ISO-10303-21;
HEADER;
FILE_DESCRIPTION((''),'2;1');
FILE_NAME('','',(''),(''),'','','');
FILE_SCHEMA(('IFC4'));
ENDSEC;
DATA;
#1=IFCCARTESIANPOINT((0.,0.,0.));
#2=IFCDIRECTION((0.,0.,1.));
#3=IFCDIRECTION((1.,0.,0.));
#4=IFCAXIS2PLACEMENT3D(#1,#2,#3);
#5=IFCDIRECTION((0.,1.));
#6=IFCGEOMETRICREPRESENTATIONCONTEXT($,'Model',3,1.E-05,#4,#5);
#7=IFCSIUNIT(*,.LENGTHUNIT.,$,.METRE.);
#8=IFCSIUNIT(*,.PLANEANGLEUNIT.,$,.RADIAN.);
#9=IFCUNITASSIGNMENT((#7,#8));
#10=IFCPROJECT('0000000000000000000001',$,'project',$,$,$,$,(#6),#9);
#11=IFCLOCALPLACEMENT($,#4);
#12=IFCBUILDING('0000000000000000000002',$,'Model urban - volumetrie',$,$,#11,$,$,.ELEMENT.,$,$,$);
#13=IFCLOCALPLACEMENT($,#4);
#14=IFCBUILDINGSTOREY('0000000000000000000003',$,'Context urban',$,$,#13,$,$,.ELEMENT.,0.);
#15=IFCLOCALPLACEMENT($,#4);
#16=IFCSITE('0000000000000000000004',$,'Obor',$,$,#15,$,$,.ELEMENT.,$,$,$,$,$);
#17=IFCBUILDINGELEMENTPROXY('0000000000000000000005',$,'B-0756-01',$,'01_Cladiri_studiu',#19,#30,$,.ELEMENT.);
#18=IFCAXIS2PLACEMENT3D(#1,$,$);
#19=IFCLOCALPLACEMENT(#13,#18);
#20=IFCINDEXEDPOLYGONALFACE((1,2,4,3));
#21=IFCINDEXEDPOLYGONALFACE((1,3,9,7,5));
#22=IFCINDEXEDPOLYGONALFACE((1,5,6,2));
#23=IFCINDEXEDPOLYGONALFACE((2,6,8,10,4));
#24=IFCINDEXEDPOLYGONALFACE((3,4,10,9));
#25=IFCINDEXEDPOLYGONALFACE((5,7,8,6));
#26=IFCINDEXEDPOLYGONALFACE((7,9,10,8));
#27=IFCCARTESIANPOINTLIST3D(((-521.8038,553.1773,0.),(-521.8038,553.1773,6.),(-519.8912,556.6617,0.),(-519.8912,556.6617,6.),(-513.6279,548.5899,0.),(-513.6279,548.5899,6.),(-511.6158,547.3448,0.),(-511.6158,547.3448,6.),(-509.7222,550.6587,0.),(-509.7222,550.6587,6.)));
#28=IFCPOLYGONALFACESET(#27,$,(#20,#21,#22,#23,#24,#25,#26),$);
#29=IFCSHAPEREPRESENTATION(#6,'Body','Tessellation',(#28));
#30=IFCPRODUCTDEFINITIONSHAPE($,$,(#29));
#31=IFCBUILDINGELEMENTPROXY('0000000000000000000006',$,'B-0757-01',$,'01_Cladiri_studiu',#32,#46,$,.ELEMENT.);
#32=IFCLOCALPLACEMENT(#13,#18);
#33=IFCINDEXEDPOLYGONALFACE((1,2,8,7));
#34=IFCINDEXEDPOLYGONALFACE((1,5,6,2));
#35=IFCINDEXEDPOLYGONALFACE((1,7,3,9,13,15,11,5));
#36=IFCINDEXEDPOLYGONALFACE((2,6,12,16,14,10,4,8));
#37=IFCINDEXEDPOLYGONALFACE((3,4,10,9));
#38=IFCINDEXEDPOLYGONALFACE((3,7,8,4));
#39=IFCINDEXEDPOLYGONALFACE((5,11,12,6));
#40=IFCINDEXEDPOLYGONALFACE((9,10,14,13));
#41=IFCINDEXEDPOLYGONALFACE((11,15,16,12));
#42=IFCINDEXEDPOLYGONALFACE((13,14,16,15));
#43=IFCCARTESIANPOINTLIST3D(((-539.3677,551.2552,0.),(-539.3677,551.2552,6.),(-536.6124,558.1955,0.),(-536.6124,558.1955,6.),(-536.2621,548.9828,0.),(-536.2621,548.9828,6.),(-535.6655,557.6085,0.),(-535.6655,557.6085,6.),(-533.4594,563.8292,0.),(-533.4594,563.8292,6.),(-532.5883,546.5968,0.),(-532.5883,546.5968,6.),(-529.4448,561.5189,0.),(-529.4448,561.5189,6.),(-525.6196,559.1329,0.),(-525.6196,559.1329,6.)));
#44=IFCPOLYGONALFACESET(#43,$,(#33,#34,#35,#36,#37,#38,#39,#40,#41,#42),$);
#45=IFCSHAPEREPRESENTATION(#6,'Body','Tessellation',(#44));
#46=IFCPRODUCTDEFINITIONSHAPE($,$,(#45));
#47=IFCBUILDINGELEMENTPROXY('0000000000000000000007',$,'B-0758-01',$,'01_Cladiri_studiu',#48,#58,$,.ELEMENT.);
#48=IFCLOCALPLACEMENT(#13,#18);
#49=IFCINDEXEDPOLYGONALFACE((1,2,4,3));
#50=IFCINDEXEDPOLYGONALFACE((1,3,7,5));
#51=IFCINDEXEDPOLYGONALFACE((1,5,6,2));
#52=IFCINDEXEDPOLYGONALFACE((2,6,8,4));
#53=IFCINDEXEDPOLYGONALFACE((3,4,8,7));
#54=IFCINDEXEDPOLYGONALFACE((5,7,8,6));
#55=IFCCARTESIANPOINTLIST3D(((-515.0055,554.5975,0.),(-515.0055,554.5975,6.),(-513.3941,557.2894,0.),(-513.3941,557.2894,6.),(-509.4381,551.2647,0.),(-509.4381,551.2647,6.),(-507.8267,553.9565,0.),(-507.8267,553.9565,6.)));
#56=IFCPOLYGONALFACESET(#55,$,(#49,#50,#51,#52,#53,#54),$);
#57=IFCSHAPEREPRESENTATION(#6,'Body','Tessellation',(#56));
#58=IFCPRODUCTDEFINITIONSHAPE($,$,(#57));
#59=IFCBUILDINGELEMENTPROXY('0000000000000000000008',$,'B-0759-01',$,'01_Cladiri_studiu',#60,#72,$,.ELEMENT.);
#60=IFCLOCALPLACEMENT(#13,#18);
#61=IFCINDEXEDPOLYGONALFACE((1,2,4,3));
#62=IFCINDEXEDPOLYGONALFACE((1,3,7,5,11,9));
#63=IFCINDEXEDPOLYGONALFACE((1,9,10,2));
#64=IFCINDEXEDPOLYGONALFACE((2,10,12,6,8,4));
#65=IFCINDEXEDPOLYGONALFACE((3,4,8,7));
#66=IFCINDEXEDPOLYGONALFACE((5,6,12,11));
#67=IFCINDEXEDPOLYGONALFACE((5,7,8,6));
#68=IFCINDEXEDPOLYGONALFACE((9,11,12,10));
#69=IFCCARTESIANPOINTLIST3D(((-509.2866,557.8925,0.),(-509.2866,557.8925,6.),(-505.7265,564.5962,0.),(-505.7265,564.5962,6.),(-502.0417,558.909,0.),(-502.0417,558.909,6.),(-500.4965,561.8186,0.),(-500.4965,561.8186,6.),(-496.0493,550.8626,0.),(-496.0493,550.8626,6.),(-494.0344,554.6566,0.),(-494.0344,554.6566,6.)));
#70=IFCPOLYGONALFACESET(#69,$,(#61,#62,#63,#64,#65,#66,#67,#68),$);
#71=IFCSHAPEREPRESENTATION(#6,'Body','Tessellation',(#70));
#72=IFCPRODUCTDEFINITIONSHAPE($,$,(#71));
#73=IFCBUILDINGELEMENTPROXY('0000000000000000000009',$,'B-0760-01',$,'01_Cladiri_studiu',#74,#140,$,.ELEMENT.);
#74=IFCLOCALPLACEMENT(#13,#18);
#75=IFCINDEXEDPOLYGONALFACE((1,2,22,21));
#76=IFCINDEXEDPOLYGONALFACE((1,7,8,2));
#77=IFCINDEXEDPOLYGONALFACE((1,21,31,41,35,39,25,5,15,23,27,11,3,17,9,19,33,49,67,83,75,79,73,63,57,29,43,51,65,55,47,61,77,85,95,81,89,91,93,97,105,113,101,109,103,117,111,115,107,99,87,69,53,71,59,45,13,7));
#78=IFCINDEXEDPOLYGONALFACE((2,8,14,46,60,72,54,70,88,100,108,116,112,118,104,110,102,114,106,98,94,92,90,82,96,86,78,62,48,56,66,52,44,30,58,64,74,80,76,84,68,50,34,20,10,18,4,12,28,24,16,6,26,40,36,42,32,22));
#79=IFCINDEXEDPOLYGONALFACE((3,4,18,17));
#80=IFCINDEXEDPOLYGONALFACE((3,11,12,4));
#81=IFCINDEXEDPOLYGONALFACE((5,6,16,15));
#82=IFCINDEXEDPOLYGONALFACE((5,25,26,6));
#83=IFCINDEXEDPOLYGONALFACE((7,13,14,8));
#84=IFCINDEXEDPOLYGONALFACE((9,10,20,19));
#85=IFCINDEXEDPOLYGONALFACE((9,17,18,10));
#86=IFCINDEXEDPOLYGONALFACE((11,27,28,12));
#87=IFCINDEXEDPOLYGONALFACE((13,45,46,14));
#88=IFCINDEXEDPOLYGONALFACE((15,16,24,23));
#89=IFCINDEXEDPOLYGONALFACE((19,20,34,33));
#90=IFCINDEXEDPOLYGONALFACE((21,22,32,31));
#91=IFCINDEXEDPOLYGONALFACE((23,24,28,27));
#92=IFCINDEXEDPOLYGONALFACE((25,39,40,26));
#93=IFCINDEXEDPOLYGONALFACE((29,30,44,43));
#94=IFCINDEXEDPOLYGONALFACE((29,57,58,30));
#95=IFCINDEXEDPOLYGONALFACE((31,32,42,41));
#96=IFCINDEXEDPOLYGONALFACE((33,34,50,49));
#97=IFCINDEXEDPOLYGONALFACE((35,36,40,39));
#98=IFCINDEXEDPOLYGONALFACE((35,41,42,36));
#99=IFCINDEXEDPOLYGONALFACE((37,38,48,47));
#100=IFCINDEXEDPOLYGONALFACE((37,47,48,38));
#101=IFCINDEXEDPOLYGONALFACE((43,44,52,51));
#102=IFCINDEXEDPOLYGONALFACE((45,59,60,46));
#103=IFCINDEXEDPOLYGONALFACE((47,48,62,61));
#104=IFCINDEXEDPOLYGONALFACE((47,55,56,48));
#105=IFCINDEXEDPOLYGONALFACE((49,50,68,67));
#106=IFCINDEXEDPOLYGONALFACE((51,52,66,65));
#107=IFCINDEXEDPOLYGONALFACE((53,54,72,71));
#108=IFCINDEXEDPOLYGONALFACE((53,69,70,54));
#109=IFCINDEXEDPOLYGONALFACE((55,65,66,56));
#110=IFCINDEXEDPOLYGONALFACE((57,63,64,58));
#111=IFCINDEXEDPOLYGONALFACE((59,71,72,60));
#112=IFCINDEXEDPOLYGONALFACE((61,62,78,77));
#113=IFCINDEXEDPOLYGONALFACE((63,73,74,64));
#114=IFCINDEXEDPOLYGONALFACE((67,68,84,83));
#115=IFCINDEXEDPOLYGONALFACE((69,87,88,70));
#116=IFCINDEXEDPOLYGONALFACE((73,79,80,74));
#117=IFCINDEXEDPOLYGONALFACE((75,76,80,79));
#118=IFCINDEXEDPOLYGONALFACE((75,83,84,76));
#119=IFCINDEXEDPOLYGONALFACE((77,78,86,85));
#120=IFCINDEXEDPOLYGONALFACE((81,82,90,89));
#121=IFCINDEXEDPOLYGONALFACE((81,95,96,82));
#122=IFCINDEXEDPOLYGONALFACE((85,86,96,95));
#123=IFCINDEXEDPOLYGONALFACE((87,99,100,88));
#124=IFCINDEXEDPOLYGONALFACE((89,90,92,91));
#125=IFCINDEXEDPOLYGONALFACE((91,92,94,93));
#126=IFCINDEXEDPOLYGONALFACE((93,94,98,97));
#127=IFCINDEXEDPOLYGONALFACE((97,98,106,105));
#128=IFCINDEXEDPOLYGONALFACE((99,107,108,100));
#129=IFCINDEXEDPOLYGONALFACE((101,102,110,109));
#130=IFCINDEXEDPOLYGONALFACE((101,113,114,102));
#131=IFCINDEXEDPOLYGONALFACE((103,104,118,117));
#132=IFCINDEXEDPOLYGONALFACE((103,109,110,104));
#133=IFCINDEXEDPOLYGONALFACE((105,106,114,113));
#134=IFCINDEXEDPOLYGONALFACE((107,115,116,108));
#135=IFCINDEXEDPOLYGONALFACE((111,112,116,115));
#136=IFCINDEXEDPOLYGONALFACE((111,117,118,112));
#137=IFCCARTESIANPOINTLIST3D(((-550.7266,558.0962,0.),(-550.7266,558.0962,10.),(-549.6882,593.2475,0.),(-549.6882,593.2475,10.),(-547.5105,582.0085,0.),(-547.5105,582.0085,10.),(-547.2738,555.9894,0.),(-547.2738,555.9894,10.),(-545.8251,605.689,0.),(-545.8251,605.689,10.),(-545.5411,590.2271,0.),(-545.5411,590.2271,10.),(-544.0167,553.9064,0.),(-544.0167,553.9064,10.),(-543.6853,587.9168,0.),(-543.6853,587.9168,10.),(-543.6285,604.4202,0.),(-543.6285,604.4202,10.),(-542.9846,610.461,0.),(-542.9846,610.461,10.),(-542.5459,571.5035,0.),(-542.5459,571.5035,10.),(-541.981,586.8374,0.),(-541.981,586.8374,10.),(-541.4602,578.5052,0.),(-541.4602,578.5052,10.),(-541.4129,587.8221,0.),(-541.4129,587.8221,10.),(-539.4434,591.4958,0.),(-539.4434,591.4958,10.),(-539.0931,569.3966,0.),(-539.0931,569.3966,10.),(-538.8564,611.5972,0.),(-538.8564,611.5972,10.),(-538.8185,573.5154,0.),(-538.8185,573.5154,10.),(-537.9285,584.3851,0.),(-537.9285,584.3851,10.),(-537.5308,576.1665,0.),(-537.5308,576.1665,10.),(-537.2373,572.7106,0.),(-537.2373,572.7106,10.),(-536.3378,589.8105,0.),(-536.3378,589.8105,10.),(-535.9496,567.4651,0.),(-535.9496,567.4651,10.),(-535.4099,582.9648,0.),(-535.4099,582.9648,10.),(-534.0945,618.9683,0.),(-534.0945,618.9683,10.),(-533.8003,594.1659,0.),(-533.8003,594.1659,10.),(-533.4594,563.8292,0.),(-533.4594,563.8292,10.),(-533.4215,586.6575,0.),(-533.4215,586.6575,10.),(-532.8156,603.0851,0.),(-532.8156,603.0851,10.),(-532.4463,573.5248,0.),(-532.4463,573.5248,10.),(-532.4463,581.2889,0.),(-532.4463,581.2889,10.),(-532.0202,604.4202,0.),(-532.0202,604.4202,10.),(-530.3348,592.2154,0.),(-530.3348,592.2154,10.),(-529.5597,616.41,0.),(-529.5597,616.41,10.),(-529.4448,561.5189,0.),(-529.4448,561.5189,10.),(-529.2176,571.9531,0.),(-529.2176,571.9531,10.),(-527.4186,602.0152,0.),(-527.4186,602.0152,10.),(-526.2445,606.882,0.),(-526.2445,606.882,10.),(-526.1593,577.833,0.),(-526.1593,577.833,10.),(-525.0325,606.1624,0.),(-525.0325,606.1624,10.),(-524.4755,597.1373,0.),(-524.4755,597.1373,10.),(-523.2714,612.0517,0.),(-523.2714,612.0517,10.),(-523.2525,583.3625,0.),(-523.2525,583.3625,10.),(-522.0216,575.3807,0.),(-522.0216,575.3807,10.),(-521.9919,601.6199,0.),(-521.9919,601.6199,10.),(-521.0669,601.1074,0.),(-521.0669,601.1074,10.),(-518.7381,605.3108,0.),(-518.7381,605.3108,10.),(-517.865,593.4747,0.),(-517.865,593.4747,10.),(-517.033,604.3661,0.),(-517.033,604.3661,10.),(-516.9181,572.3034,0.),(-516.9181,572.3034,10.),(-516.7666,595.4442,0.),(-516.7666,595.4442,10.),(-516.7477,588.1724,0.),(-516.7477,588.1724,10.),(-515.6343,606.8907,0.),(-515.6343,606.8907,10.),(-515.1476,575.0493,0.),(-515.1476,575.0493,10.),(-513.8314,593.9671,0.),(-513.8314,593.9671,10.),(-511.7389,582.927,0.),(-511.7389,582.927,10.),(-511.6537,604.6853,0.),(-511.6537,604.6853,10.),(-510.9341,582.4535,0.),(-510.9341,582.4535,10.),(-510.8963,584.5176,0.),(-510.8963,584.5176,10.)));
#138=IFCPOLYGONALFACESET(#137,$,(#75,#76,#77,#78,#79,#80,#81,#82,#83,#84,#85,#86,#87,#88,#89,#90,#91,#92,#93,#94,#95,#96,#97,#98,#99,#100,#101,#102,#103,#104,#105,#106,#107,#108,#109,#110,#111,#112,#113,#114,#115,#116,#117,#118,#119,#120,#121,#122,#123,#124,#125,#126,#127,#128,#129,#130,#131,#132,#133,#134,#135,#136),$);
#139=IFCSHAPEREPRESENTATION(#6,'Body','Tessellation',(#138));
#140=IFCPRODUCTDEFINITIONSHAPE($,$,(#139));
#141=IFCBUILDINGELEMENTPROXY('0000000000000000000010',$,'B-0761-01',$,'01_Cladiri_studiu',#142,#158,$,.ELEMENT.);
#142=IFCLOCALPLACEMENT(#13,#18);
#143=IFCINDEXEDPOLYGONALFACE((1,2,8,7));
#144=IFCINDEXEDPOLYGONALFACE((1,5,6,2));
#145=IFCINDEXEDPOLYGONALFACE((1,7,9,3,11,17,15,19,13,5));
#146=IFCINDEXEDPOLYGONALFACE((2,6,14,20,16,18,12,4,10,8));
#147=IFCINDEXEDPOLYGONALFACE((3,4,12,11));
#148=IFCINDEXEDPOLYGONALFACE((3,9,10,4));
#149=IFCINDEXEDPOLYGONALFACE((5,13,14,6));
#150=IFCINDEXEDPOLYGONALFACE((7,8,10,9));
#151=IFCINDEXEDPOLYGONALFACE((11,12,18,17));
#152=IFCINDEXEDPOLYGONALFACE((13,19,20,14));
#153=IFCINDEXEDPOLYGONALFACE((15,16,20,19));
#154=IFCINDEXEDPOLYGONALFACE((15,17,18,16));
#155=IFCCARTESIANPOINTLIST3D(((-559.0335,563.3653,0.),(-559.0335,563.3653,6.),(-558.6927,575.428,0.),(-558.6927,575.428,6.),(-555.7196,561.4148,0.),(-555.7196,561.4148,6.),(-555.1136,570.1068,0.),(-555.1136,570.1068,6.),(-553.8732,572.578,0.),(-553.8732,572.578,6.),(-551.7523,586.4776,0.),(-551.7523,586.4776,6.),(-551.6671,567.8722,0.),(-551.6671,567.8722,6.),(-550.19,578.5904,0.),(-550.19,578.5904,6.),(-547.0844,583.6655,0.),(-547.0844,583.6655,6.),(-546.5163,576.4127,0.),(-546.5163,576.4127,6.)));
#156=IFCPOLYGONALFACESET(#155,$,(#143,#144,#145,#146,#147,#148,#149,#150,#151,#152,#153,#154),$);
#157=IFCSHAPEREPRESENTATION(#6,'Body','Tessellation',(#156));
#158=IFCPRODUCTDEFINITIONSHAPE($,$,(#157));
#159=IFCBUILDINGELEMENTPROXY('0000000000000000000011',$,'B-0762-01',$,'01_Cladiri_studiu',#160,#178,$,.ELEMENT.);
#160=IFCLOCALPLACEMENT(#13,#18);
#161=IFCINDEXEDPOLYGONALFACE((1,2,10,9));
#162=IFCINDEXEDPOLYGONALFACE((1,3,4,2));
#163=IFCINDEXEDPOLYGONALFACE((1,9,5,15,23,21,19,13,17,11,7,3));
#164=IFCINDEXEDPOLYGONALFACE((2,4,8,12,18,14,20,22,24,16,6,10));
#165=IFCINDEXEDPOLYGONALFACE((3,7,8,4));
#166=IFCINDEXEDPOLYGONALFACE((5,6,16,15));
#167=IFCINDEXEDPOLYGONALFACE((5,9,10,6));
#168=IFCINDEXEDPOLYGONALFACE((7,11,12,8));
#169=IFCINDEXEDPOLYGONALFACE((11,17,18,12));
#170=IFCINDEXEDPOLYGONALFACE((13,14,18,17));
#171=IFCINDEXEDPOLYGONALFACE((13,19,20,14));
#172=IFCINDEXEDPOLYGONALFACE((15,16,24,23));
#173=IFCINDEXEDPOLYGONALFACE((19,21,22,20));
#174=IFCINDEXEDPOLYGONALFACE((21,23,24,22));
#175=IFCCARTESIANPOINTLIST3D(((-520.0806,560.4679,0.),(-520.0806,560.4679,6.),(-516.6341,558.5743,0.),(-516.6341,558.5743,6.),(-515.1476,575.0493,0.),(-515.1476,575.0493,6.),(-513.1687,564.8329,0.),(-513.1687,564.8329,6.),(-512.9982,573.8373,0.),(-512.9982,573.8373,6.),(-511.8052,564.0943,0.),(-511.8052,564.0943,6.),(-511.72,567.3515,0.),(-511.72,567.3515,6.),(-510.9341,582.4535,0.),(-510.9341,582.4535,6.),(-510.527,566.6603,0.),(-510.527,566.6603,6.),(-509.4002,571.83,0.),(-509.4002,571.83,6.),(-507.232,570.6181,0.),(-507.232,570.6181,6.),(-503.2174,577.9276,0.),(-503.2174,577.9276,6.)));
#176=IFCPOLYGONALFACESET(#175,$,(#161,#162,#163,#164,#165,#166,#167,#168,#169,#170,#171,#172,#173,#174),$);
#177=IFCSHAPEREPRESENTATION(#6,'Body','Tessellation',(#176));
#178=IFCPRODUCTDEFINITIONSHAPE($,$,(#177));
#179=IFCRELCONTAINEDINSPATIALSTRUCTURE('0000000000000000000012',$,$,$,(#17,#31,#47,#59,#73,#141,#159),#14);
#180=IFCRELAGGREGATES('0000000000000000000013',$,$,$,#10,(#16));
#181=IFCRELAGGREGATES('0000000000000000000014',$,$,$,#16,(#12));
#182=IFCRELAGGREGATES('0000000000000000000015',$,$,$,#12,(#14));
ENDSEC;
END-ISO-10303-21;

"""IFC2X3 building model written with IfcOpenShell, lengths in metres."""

from ifc_helpers import new_model, si_unit, direction, origin_with_axes, place, context, project, spatial, polyline, outline, extrude, element, save


model = new_model("IFC2X3")

# Units and contexts
model_context = context("Model", 3, precision=1e-05, world=origin_with_axes(), true_north=direction((0.0, 1.0)))
ifc_project = project(units=[si_unit("LENGTHUNIT", "METRE"), si_unit("PLANEANGLEUNIT", "RADIAN")], contexts=[model_context])

# Site, building, storey
site_placement = place(None, origin_with_axes())
site = spatial("IfcSite", under=ifc_project, at=site_placement, Name="Obor", CompositionType="ELEMENT")
building_placement = place(None, origin_with_axes())
building = spatial("IfcBuilding", under=site, at=building_placement, Name="Model urban - volumetrie", CompositionType="ELEMENT")
storey_placement = place(None, origin_with_axes())
storey = spatial("IfcBuildingStorey", under=building, at=storey_placement, Name="Context urban", CompositionType="ELEMENT", Elevation=0.0)

# Building element proxies
proxy_1_placement = place(None, origin_with_axes())
element("IfcBuildingElementProxy", 1, at=proxy_1_placement, inside=storey, Name="B-0756-01", ObjectType="01_Cladiri_studiu", CompositionType="ELEMENT", context=model_context, shape_type="SweptSolid", body=[
    extrude(outline(polyline([(-521.8038, 553.1773), (-513.6279, 548.5899), (-511.6158, 547.3448), (-509.7222, 550.6587), (-519.8912, 556.6617), (-521.8038, 553.1773)])), origin_with_axes(), (0.0, 0.0, 1.0), 6.0),
])
proxy_2_placement = place(None, origin_with_axes())
element("IfcBuildingElementProxy", 2, at=proxy_2_placement, inside=storey, Name="B-0757-01", ObjectType="01_Cladiri_studiu", CompositionType="ELEMENT", context=model_context, shape_type="SweptSolid", body=[
    extrude(outline(polyline([(-532.5883, 546.5968), (-525.6196, 559.1329), (-529.4448, 561.5189), (-533.4594, 563.8292), (-536.6124, 558.1955), (-535.6655, 557.6085), (-539.3677, 551.2552), (-536.2621, 548.9828), (-532.5883, 546.5968)])), origin_with_axes(), (0.0, 0.0, 1.0), 6.0),
])
proxy_3_placement = place(None, origin_with_axes())
element("IfcBuildingElementProxy", 3, at=proxy_3_placement, inside=storey, Name="B-0758-01", ObjectType="01_Cladiri_studiu", CompositionType="ELEMENT", context=model_context, shape_type="SweptSolid", body=[
    extrude(outline(polyline([(-507.8267, 553.9565), (-513.3941, 557.2894), (-515.0055, 554.5975), (-509.4381, 551.2647), (-507.8267, 553.9565)])), origin_with_axes(), (0.0, 0.0, 1.0), 6.0),
])
proxy_4_placement = place(None, origin_with_axes())
element("IfcBuildingElementProxy", 4, at=proxy_4_placement, inside=storey, Name="B-0759-01", ObjectType="01_Cladiri_studiu", CompositionType="ELEMENT", context=model_context, shape_type="SweptSolid", body=[
    extrude(outline(polyline([(-502.0417, 558.909), (-500.4965, 561.8186), (-505.7265, 564.5962), (-509.2866, 557.8925), (-496.0493, 550.8626), (-494.0344, 554.6566), (-502.0417, 558.909)])), origin_with_axes(), (0.0, 0.0, 1.0), 6.0),
])
proxy_5_placement = place(None, origin_with_axes())
element("IfcBuildingElementProxy", 5, at=proxy_5_placement, inside=storey, Name="B-0760-01", ObjectType="01_Cladiri_studiu", CompositionType="ELEMENT", context=model_context, shape_type="SweptSolid", body=[
    extrude(outline(polyline([(-537.5308, 576.1665), (-538.8185, 573.5154), (-537.2373, 572.7106), (-539.0931, 569.3966), (-542.5459, 571.5035), (-550.7266, 558.0962), (-547.2738, 555.9894), (-544.0167, 553.9064), (-535.9496, 567.4651), (-532.4463, 573.5248), (-529.2176, 571.9531), (-533.4594, 563.8292), (-529.4448, 561.5189), (-522.0216, 575.3807), (-516.9181, 572.3034), (-515.1476, 575.0493), (-510.9341, 582.4535), (-511.7389, 582.927), (-510.8963, 584.5176), (-516.7477, 588.1724), (-513.8314, 593.9671), (-516.7666, 595.4442), (-511.6537, 604.6853), (-515.6343, 606.8907), (-517.033, 604.3661), (-518.7381, 605.3108), (-521.0669, 601.1074), (-521.9919, 601.6199), (-524.4755, 597.1373), (-517.865, 593.4747), (-523.2525, 583.3625), (-526.1593, 577.833), (-532.4463, 581.2889), (-535.4099, 582.9648), (-537.9285, 584.3851), (-535.4099, 582.9648), (-533.4215, 586.6575), (-530.3348, 592.2154), (-533.8003, 594.1659), (-536.3378, 589.8105), (-539.4434, 591.4958), (-532.8156, 603.0851), (-532.0202, 604.4202), (-527.4186, 602.0152), (-525.0325, 606.1624), (-526.2445, 606.882), (-523.2714, 612.0517), (-529.5597, 616.41), (-534.0945, 618.9683), (-538.8564, 611.5972), (-542.9846, 610.461), (-545.8251, 605.689), (-543.6285, 604.4202), (-549.6882, 593.2475), (-545.5411, 590.2271), (-541.4129, 587.8221), (-541.981, 586.8374), (-543.6853, 587.9168), (-547.5105, 582.0085), (-541.4602, 578.5052), (-537.5308, 576.1665)])), origin_with_axes(), (0.0, 0.0, 1.0), 10.0),
])
proxy_6_placement = place(None, origin_with_axes())
element("IfcBuildingElementProxy", 6, at=proxy_6_placement, inside=storey, Name="B-0761-01", ObjectType="01_Cladiri_studiu", CompositionType="ELEMENT", context=model_context, shape_type="SweptSolid", body=[
    extrude(outline(polyline([(-555.1136, 570.1068), (-559.0335, 563.3653), (-555.7196, 561.4148), (-551.6671, 567.8722), (-546.5163, 576.4127), (-550.19, 578.5904), (-547.0844, 583.6655), (-551.7523, 586.4776), (-558.6927, 575.428), (-553.8732, 572.578), (-555.1136, 570.1068)])), origin_with_axes(), (0.0, 0.0, 1.0), 6.0),
])
proxy_7_placement = place(None, origin_with_axes())
element("IfcBuildingElementProxy", 7, at=proxy_7_placement, inside=storey, Name="B-0762-01", ObjectType="01_Cladiri_studiu", CompositionType="ELEMENT", context=model_context, shape_type="SweptSolid", body=[
    extrude(outline(polyline([(-509.4002, 571.83), (-507.232, 570.6181), (-503.2174, 577.9276), (-510.9341, 582.4535), (-515.1476, 575.0493), (-512.9982, 573.8373), (-520.0806, 560.4679), (-516.6341, 558.5743), (-513.1687, 564.8329), (-511.8052, 564.0943), (-510.527, 566.6603), (-511.72, 567.3515), (-509.4002, 571.83)])), origin_with_axes(), (0.0, 0.0, 1.0), 6.0),
])

save(model, "model.ifc")
